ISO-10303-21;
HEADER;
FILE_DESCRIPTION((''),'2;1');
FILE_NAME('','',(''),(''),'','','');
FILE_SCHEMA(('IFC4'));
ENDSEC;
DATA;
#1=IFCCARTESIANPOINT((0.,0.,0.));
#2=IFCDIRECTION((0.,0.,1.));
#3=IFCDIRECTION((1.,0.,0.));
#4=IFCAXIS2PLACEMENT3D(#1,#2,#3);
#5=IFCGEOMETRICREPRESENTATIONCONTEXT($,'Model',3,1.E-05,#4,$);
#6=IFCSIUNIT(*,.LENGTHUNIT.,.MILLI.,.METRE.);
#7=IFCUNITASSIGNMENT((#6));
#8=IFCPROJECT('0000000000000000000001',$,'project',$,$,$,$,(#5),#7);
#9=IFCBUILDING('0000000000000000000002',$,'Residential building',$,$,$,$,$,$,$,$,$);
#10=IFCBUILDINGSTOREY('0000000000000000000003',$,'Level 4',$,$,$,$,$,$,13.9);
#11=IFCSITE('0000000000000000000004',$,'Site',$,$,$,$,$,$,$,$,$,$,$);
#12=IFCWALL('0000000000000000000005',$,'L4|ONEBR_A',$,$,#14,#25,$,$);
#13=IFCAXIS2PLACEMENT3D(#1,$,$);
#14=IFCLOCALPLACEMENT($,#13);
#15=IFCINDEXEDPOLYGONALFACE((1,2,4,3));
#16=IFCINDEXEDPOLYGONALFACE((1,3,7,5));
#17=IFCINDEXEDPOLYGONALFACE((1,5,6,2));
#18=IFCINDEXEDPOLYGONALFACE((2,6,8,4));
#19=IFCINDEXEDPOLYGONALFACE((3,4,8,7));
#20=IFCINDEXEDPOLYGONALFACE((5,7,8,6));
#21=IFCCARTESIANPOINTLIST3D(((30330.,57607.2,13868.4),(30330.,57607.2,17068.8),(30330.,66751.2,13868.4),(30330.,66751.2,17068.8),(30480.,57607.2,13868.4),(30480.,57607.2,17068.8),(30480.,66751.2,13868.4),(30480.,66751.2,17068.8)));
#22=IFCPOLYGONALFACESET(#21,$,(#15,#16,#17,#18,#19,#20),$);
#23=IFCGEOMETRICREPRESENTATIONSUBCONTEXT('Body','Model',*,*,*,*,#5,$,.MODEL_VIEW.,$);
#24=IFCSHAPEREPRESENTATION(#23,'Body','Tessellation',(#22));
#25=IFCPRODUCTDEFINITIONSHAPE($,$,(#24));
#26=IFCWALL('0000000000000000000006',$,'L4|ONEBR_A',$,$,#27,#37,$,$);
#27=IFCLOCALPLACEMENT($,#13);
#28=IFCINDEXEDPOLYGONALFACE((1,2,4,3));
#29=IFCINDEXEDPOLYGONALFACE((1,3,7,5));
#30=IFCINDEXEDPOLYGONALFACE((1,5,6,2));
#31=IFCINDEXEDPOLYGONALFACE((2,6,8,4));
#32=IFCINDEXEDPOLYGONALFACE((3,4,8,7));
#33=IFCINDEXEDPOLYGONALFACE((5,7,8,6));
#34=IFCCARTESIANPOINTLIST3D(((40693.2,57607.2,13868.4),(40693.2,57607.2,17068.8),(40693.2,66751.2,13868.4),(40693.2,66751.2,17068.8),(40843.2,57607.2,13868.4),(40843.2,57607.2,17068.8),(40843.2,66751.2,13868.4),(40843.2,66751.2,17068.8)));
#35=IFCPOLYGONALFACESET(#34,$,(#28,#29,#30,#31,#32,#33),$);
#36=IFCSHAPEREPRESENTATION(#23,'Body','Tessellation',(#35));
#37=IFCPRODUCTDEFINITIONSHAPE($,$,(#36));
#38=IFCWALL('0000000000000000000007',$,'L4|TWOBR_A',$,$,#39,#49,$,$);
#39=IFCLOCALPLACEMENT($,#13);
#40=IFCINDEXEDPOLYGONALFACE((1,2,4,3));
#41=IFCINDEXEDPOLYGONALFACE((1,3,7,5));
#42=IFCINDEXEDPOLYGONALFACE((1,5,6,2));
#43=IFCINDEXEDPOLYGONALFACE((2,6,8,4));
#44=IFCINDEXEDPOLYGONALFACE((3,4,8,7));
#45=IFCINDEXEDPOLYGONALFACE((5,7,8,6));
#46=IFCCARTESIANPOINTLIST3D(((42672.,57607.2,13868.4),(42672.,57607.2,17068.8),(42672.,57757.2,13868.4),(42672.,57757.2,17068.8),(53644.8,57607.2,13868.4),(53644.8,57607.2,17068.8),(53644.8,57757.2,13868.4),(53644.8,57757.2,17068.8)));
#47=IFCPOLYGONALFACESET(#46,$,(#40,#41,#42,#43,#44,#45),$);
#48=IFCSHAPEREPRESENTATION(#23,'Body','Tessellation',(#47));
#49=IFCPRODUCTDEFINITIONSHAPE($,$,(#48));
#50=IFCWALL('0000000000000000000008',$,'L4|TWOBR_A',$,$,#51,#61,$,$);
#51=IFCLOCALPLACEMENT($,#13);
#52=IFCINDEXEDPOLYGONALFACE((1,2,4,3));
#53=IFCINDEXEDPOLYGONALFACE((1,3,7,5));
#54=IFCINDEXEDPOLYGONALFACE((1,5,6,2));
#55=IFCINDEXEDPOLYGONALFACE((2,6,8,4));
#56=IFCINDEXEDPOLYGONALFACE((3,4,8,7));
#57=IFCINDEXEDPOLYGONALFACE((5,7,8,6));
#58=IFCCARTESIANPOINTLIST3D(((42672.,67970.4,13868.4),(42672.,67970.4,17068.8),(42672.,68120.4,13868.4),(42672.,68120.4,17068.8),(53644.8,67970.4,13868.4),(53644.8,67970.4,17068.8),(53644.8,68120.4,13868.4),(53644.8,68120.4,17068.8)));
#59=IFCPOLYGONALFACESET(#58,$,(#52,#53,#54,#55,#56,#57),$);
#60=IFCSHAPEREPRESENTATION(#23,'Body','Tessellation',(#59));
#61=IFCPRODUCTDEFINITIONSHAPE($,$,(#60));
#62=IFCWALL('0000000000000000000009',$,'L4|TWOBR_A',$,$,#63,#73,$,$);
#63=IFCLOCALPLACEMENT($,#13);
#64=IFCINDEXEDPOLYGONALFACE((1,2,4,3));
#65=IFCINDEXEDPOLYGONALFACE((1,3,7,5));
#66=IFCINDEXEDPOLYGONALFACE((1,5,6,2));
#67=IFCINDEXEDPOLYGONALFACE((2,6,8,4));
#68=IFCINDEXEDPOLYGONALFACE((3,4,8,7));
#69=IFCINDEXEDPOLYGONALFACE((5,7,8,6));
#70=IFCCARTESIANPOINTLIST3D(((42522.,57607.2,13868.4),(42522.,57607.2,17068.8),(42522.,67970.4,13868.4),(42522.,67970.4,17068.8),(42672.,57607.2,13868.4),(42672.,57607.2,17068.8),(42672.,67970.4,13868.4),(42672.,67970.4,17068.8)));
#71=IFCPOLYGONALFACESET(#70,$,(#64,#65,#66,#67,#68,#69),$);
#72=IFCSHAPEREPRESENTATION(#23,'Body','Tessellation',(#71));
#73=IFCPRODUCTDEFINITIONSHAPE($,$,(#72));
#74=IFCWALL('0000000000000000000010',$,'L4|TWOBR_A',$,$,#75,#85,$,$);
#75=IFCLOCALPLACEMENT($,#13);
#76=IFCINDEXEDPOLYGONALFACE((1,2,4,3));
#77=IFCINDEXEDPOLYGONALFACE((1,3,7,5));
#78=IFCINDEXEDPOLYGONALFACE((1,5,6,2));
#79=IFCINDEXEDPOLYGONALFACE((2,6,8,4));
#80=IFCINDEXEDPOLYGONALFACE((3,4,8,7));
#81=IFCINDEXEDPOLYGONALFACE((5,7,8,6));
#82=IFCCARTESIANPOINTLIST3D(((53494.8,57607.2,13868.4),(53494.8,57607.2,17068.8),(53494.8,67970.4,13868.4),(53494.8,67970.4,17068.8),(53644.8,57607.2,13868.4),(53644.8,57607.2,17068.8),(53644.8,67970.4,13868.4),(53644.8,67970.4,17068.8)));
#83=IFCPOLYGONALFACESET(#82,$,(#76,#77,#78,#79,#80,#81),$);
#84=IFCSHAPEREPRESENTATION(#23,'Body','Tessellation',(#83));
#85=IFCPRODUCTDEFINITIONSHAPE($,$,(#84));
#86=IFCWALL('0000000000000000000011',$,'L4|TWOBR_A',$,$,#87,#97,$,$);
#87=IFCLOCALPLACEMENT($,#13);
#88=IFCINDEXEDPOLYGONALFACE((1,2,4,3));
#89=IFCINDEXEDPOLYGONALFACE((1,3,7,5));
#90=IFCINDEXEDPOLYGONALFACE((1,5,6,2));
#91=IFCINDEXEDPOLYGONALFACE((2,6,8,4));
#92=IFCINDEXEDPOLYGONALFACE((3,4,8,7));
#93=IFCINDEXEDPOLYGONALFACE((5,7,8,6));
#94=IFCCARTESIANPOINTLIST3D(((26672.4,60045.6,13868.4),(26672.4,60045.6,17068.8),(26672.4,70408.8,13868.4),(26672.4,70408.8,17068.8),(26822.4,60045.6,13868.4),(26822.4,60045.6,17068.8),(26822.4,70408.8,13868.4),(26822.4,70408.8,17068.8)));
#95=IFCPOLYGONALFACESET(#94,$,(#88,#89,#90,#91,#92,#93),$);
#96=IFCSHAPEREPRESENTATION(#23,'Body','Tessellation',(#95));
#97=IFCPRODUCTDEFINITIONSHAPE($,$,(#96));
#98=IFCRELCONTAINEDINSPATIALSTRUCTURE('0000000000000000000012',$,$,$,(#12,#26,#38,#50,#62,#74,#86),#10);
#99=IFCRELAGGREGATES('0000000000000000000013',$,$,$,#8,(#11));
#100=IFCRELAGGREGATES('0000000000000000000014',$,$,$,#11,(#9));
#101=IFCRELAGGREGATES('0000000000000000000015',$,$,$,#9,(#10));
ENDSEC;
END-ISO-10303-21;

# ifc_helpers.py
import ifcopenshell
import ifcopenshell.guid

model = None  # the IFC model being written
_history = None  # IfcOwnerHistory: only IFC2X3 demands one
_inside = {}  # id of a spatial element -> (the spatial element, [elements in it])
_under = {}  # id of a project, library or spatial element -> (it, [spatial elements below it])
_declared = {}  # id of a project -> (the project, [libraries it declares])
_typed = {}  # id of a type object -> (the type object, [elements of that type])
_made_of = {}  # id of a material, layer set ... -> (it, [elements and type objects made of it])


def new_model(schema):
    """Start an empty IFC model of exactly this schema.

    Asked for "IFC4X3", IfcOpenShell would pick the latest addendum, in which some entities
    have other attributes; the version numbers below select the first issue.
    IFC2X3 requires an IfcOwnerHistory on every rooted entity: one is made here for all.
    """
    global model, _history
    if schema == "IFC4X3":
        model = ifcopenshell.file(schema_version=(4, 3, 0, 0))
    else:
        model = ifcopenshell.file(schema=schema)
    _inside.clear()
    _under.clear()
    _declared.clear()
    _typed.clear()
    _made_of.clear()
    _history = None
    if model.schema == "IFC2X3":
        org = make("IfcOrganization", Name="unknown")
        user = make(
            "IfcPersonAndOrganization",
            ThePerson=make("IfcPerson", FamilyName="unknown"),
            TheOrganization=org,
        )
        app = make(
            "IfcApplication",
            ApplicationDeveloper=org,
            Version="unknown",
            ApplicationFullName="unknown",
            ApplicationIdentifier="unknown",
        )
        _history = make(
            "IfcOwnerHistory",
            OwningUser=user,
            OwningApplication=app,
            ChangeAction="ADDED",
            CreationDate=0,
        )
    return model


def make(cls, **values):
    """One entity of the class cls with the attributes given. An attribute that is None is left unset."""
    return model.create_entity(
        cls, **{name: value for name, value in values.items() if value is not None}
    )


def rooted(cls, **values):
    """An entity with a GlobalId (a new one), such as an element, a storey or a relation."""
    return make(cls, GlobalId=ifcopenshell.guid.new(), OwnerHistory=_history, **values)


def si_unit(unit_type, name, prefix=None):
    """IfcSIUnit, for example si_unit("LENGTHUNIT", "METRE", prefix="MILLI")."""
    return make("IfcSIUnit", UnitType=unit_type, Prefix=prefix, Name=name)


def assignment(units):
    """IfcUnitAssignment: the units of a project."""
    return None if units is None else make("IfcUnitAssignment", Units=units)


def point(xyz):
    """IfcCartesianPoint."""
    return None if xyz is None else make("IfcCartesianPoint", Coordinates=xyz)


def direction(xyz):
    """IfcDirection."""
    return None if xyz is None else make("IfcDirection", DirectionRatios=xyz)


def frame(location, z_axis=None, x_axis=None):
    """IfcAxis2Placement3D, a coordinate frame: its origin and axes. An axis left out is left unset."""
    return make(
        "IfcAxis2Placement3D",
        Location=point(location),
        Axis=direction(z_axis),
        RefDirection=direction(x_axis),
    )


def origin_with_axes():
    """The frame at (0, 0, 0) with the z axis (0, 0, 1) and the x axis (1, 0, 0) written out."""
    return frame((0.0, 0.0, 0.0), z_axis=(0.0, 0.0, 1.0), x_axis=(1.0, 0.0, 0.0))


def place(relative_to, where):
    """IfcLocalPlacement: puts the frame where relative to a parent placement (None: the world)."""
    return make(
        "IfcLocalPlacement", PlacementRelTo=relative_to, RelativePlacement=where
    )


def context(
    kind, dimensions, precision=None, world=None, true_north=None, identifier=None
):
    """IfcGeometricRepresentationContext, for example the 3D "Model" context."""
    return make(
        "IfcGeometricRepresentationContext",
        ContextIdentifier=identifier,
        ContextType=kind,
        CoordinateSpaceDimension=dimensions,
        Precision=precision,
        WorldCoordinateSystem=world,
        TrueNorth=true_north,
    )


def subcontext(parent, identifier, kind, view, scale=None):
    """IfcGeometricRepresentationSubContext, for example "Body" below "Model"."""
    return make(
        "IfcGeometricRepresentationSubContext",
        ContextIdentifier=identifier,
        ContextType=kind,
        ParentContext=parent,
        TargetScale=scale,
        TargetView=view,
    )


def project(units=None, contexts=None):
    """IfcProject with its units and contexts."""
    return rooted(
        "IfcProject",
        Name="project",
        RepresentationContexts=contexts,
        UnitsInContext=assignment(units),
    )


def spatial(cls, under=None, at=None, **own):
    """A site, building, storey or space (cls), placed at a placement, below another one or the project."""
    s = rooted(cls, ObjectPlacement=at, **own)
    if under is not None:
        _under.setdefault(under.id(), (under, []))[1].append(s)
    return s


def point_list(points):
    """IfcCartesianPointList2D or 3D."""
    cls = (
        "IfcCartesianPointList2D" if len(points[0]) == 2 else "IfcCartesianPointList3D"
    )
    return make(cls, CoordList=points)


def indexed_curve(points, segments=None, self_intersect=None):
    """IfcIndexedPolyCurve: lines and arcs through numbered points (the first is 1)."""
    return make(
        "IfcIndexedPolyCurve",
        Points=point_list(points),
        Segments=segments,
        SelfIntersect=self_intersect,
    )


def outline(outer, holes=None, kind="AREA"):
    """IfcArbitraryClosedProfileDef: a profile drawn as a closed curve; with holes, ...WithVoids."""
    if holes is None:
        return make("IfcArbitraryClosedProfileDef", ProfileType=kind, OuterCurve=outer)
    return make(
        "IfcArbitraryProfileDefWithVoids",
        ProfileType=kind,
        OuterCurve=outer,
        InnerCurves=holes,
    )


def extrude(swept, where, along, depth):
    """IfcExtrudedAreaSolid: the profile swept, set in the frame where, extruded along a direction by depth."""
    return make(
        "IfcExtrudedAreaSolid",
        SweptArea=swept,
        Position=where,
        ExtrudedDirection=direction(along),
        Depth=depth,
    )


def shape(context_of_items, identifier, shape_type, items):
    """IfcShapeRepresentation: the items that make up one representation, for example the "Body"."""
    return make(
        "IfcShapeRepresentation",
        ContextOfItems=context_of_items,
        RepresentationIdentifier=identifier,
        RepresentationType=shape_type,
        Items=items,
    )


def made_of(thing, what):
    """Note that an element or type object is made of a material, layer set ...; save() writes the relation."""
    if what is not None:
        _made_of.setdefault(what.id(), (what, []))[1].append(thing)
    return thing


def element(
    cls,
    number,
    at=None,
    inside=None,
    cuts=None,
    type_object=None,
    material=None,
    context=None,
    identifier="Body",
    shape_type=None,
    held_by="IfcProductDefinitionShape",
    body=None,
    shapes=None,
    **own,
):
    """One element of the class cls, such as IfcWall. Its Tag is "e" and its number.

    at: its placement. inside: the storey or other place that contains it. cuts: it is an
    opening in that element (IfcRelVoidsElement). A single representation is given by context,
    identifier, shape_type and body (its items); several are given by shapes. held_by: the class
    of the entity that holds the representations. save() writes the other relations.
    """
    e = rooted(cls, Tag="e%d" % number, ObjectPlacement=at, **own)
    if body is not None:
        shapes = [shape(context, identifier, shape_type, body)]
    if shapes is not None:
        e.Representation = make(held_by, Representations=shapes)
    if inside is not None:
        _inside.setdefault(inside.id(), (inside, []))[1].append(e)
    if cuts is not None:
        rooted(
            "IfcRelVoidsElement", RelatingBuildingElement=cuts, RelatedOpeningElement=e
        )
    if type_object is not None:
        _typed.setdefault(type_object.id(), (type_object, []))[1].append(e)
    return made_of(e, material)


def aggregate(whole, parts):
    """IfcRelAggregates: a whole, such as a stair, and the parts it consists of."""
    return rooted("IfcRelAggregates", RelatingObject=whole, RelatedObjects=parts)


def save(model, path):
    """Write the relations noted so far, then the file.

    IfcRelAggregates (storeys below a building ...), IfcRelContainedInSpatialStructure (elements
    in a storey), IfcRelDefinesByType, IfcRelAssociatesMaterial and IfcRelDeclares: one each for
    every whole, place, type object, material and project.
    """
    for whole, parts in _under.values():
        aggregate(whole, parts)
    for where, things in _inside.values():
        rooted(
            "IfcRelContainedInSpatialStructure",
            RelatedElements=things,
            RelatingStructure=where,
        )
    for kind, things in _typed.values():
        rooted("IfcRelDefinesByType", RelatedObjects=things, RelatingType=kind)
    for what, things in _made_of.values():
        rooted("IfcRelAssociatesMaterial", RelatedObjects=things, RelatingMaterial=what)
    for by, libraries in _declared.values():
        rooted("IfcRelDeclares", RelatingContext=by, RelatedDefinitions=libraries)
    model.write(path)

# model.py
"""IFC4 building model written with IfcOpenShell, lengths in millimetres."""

from ifc_helpers import new_model, si_unit, frame, origin_with_axes, place, context, subcontext, project, spatial, indexed_curve, outline, extrude, element, save


model = new_model("IFC4")

# Units and contexts
model_context = context("Model", 3, precision=1e-05, world=origin_with_axes())
body_context = subcontext(model_context, "Body", "Model", "MODEL_VIEW")
ifc_project = project(units=[si_unit("LENGTHUNIT", "METRE", prefix="MILLI")], contexts=[model_context])

# Site, building, storey
site = spatial("IfcSite", under=ifc_project, Name="Site")
building = spatial("IfcBuilding", under=site, Name="Residential building")
storey = spatial("IfcBuildingStorey", under=building, Name="Level 4", Elevation=13.9)

# Walls
for number, where, z_axis, x_axis, name in (
    (1, (30480.0, 57607.2, 13868.4), (0.0, 0.0, 1.0), (0.0, 1.0, 0.0), "L4|ONEBR_A"),
    (2, (40843.2, 57607.2, 13868.4), (0.0, 0.0, 1.0), (0.0, 1.0, 0.0), "L4|ONEBR_A"),
):
    element("IfcWall", number, at=place(None, frame(where, z_axis=z_axis, x_axis=x_axis)), inside=storey, Name=name, context=body_context, shape_type="SweptSolid", body=[
        extrude(outline(indexed_curve([(0.0, 0.0), (0.0, 150.0), (9144.0, 150.0), (9144.0, 0.0), (0.0, 0.0)], self_intersect=False)), origin_with_axes(), (0.0, 0.0, 1.0), 3200.4),
    ])
for number, where, z_axis, x_axis, name in (
    (3, (42672.0, 57607.2, 13868.4), (0.0, 0.0, 1.0), (1.0, 0.0, 0.0), "L4|TWOBR_A"),
    (4, (42672.0, 67970.4, 13868.4), (0.0, 0.0, 1.0), (1.0, 0.0, 0.0), "L4|TWOBR_A"),
):
    element("IfcWall", number, at=place(None, frame(where, z_axis=z_axis, x_axis=x_axis)), inside=storey, Name=name, context=body_context, shape_type="SweptSolid", body=[
        extrude(outline(indexed_curve([(0.0, 0.0), (0.0, 150.0), (10972.8, 150.0), (10972.8, 0.0), (0.0, 0.0)], self_intersect=False)), origin_with_axes(), (0.0, 0.0, 1.0), 3200.4),
    ])
for number, where, z_axis, x_axis, name in (
    (5, (42672.0, 57607.2, 13868.4), (0.0, 0.0, 1.0), (0.0, 1.0, 0.0), "L4|TWOBR_A"),
    (6, (53644.8, 57607.2, 13868.4), (0.0, 0.0, 1.0), (0.0, 1.0, 0.0), "L4|TWOBR_A"),
    (7, (26822.4, 60045.6, 13868.4), (0.0, 0.0, 1.0), (0.0, 1.0, 0.0), "L4|TWOBR_A"),
):
    element("IfcWall", number, at=place(None, frame(where, z_axis=z_axis, x_axis=x_axis)), inside=storey, Name=name, context=body_context, shape_type="SweptSolid", body=[
        extrude(outline(indexed_curve([(0.0, 0.0), (0.0, 150.0), (10363.2, 150.0), (10363.2, 0.0), (0.0, 0.0)], self_intersect=False)), origin_with_axes(), (0.0, 0.0, 1.0), 3200.4),
    ])

save(model, "model.ifc")
